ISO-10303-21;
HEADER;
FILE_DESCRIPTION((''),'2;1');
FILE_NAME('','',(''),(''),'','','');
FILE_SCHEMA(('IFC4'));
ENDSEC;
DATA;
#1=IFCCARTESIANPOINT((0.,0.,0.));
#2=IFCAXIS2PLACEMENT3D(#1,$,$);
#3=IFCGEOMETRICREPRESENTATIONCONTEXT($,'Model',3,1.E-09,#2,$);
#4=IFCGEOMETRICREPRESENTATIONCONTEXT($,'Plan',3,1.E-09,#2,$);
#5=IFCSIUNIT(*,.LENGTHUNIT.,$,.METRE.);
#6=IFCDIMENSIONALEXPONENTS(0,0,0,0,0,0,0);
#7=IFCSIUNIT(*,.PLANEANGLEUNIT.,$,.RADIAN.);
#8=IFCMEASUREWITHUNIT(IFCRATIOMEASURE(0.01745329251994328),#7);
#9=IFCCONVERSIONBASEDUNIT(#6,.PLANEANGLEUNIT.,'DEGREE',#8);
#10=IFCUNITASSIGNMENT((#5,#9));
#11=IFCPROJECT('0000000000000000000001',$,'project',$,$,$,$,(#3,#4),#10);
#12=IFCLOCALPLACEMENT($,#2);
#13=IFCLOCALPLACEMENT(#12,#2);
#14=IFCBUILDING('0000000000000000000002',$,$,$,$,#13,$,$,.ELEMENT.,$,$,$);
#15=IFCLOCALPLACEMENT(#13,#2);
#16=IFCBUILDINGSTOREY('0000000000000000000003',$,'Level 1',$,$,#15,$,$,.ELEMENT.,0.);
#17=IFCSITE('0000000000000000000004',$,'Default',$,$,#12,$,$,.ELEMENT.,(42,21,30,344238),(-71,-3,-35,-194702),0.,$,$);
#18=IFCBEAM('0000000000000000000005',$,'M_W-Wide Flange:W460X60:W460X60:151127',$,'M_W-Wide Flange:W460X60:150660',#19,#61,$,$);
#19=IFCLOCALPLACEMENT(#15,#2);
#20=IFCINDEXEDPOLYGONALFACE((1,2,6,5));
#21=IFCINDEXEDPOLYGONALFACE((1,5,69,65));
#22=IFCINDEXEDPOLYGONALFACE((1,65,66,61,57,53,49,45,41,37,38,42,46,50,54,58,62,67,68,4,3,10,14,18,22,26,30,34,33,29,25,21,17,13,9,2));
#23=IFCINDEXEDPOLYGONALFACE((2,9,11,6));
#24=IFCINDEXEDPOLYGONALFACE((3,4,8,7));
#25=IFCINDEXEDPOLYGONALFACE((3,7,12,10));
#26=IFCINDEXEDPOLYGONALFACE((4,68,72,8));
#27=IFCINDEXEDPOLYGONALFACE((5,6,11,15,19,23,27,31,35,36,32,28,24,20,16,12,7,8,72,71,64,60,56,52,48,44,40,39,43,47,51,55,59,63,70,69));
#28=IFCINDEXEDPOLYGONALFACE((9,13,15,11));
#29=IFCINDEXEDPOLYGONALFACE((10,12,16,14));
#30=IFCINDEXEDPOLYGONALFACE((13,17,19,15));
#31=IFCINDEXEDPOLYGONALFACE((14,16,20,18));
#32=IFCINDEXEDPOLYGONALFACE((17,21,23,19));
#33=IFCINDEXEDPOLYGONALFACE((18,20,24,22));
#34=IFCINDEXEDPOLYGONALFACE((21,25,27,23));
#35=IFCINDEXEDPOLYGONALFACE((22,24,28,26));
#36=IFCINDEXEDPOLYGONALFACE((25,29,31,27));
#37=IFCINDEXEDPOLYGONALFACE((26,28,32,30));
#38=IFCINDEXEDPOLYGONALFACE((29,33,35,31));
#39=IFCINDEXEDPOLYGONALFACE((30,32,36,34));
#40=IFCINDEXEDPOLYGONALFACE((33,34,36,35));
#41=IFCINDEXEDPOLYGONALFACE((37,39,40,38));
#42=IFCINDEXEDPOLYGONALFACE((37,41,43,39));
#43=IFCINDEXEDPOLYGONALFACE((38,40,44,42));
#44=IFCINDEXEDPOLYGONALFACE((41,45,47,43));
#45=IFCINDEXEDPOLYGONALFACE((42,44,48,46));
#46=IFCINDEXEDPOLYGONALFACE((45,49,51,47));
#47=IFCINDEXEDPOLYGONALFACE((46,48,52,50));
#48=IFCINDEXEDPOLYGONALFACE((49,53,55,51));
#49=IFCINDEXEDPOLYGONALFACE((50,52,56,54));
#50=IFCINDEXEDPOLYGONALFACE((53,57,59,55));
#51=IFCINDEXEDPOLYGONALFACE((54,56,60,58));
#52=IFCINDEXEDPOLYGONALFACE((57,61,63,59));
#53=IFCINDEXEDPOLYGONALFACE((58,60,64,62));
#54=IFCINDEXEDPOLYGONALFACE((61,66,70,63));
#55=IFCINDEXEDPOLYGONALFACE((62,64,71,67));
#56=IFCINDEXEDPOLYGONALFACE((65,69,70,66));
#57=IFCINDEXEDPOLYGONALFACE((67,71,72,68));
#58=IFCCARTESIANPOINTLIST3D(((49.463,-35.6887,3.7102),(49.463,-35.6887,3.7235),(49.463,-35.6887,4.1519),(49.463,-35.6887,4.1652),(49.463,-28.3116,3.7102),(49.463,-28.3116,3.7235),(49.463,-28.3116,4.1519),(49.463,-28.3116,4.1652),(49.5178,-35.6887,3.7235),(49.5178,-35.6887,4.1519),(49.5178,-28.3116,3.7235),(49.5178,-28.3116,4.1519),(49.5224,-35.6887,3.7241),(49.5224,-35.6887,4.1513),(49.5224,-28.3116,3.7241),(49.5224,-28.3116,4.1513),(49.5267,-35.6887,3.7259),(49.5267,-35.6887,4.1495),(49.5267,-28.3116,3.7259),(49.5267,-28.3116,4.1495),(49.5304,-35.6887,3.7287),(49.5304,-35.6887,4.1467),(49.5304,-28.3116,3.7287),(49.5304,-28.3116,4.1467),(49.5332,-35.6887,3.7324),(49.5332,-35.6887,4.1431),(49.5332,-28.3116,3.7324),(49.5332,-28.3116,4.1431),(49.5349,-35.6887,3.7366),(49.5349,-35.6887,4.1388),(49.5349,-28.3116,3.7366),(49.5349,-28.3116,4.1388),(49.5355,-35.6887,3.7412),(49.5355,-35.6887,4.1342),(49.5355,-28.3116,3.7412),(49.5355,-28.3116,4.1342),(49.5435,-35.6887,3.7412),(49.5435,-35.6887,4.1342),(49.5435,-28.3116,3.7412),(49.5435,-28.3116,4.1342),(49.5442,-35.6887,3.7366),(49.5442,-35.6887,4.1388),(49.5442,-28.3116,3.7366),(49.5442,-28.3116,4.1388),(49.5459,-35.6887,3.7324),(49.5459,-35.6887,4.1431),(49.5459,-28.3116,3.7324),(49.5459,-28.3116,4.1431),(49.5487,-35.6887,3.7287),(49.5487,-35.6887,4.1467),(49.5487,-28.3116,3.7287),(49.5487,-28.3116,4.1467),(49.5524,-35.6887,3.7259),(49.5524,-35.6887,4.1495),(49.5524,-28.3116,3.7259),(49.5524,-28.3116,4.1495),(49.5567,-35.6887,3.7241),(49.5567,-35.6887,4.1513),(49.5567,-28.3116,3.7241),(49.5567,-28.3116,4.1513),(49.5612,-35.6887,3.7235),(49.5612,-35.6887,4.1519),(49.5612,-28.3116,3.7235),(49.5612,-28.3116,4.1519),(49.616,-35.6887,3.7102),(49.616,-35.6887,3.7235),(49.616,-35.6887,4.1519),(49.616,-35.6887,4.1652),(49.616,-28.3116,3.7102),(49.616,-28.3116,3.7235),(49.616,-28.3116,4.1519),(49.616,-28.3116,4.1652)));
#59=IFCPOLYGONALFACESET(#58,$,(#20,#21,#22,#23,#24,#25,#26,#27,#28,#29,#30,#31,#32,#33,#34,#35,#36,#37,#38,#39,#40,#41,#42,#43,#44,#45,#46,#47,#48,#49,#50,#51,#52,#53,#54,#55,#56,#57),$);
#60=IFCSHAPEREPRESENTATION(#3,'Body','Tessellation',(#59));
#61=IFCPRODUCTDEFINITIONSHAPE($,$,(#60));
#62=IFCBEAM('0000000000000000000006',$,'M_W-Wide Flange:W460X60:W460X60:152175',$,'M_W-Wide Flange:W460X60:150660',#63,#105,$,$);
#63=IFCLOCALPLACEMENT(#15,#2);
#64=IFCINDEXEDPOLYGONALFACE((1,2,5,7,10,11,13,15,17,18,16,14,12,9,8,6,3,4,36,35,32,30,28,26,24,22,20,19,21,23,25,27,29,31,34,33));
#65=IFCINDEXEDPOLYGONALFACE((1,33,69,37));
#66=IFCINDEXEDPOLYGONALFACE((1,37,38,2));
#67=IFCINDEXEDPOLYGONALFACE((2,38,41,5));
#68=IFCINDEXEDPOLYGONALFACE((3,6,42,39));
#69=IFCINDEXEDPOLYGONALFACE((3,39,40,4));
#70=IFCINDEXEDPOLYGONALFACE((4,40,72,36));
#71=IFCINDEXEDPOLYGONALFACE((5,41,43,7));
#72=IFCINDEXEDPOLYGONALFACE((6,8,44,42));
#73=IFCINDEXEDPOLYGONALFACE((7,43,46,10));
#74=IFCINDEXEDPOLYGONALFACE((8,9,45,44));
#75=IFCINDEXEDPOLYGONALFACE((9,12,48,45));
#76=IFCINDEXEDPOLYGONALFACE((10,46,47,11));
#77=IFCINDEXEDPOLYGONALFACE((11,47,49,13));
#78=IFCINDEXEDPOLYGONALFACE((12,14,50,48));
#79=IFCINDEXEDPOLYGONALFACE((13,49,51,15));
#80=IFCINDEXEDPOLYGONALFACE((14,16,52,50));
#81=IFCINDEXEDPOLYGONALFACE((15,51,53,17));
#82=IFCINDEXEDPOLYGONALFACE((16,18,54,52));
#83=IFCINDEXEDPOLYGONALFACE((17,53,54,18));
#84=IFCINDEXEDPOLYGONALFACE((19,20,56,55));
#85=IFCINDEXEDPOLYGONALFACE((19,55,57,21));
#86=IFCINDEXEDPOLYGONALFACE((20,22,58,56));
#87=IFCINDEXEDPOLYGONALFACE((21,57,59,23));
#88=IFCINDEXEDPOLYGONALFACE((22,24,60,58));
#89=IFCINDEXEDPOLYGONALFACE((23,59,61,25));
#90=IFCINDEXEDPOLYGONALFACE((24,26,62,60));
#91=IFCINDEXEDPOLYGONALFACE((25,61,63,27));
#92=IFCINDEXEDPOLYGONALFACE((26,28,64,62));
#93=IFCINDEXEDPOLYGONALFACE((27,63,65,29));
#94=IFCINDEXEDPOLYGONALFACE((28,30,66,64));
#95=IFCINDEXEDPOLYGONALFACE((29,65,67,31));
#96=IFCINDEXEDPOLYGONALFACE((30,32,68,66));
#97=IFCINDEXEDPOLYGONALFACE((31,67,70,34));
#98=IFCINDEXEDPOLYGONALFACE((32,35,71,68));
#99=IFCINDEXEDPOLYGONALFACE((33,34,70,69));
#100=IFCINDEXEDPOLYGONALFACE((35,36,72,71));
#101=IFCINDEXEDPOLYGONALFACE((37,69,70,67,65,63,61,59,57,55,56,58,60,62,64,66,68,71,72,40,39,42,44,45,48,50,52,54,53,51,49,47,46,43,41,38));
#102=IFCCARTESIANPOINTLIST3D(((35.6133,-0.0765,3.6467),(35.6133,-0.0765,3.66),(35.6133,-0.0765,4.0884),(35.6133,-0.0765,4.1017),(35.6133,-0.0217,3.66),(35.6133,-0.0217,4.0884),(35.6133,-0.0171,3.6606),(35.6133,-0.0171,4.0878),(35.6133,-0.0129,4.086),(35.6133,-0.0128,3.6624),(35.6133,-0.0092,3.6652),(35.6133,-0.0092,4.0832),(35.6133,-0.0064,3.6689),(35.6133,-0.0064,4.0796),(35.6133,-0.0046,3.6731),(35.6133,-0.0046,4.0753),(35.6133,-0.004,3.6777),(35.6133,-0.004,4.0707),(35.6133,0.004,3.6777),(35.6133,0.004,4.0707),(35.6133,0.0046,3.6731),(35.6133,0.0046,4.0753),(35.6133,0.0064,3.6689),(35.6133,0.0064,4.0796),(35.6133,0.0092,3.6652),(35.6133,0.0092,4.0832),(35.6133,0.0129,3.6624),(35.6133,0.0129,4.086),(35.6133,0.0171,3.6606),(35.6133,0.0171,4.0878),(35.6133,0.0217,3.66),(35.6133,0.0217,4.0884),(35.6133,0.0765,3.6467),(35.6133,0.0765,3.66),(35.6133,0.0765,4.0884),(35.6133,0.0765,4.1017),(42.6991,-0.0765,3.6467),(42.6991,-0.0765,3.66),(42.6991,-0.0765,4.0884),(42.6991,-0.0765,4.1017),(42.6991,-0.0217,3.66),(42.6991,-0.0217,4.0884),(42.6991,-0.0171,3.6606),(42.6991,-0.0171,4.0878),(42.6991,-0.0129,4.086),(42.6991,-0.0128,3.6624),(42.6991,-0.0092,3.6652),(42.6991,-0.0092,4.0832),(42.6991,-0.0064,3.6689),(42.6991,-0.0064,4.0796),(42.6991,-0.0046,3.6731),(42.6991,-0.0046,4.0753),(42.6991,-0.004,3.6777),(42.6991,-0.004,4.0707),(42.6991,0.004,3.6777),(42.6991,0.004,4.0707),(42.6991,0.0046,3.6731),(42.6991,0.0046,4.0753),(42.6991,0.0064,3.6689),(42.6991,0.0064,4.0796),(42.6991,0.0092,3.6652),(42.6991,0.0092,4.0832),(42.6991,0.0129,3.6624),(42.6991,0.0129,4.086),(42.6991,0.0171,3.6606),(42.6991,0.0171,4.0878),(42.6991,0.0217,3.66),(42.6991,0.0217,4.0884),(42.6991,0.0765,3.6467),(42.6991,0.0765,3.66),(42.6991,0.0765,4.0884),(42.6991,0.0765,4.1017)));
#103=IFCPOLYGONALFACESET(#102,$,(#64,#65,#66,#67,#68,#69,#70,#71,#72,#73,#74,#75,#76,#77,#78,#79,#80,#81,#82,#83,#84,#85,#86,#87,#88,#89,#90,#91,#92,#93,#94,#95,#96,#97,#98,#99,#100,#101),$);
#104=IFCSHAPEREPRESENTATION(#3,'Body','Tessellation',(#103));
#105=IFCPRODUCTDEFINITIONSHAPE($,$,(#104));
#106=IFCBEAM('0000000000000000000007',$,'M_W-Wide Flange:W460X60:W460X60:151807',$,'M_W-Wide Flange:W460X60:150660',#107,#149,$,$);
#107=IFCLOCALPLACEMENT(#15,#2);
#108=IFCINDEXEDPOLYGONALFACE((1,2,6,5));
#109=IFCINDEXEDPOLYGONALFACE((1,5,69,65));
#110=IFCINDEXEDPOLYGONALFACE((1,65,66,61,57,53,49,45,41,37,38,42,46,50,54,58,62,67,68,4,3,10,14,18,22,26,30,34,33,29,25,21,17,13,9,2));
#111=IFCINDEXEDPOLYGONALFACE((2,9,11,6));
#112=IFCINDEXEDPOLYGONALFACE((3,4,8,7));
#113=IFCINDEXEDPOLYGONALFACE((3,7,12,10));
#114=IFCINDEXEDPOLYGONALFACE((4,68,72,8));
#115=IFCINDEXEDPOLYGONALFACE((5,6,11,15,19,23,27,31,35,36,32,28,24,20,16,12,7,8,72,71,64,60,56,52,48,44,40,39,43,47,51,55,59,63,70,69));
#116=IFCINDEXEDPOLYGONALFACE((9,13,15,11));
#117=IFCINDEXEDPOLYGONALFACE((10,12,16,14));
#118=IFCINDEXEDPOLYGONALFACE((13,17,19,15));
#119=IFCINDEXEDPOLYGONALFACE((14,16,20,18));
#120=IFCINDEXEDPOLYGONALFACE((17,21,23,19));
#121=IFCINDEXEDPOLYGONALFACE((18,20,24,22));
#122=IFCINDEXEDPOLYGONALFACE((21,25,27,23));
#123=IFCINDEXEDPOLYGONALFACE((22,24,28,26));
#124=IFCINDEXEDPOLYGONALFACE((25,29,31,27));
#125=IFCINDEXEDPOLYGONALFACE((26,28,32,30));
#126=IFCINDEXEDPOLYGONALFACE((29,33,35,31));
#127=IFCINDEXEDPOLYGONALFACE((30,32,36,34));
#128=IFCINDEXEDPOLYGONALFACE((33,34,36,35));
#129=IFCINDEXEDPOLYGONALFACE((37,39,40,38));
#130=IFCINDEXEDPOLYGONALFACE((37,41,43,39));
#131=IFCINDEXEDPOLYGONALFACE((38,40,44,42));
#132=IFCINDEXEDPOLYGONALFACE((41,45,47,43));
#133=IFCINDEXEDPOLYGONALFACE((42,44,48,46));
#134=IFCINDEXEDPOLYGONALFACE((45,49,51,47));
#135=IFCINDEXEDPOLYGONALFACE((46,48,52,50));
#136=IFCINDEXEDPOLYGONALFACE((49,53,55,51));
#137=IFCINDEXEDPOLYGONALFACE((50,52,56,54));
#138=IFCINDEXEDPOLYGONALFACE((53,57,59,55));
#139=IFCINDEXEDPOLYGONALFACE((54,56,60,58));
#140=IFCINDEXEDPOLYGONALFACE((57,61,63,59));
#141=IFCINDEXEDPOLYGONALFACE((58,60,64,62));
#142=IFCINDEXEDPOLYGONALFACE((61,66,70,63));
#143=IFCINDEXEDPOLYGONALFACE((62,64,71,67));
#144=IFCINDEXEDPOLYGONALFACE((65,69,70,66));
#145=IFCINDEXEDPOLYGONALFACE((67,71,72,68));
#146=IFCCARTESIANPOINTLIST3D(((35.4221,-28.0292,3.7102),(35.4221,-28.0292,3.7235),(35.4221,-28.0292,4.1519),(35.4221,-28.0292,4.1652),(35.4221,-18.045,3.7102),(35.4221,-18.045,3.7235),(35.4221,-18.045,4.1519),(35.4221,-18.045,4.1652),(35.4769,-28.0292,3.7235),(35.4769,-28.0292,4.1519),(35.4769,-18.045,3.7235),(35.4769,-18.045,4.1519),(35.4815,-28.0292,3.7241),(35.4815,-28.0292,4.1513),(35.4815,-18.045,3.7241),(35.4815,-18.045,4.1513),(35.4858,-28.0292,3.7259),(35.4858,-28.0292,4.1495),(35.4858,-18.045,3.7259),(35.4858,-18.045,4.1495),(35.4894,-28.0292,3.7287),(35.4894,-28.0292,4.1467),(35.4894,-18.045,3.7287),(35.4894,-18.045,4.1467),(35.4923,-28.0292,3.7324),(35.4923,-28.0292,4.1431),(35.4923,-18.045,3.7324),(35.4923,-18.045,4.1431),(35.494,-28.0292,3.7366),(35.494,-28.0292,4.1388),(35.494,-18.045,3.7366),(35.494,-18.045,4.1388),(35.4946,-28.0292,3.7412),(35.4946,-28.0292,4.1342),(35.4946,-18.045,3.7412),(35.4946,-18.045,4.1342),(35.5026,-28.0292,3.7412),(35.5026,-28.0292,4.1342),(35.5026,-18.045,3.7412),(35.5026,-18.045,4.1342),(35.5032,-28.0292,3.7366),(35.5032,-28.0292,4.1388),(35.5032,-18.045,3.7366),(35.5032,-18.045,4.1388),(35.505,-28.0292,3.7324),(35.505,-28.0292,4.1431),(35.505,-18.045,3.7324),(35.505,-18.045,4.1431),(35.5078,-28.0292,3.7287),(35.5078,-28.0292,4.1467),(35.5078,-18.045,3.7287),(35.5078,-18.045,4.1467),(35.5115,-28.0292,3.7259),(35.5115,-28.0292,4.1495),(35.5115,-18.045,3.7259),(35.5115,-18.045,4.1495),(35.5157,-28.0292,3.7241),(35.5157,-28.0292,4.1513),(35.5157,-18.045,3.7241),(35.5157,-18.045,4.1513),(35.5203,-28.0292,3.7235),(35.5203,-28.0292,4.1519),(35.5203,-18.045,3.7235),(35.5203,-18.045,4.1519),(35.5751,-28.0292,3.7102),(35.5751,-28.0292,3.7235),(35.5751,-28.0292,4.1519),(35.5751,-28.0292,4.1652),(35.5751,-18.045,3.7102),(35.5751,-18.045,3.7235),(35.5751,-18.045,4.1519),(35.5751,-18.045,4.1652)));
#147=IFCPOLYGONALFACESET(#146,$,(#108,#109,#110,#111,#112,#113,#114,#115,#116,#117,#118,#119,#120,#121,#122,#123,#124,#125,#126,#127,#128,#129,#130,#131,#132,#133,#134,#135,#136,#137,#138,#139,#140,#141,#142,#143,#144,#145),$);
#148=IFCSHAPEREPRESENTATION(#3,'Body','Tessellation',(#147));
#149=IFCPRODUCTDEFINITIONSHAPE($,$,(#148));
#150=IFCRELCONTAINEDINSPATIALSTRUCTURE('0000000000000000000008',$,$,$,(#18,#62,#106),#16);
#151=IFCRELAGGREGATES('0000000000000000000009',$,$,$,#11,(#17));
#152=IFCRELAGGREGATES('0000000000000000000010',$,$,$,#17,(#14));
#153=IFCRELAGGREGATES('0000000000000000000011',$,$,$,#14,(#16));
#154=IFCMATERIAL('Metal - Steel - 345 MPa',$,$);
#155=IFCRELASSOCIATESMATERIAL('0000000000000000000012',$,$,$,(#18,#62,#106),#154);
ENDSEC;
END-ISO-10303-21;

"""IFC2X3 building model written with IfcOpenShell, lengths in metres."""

from ifc_helpers import new_model, entity, si_unit, converted_unit, frame, frame_2d, origin, place, context, project, spatial, polyline, circle_curve, parameter, trimmed, segment, composite_curve, outline, extrude, material, element, save


model = new_model("IFC2X3")

# Units and contexts
model_context = context("Model", 3, precision=1e-09, world=origin())
plan_context = context("Plan", 3, precision=1e-09, world=origin())
ifc_project = project(units=[si_unit("LENGTHUNIT", "METRE"), converted_unit("PLANEANGLEUNIT", "DEGREE", entity("IfcRatioMeasure", 0.01745329251994328), si_unit("PLANEANGLEUNIT", "RADIAN"), dimensions=[0, 0, 0, 0, 0, 0, 0])], contexts=[model_context, plan_context])

# Site, building, storey
site_placement = place(None, origin())
site = spatial("IfcSite", under=ifc_project, at=site_placement, Name="Default", CompositionType="ELEMENT", RefLatitude=(42, 21, 30, 344238), RefLongitude=(-71, -3, -35, -194702), RefElevation=0.0)
building_placement = place(site_placement, origin())
building = spatial("IfcBuilding", under=site, at=building_placement, CompositionType="ELEMENT")
storey_placement = place(building_placement, origin())
storey = spatial("IfcBuildingStorey", under=building, at=storey_placement, Name="Level 1", CompositionType="ELEMENT", Elevation=0.0)

# Beams
ifc_material = material(Name="Metal - Steel - 345 MPa")
beam_1_placement = place(storey_placement, frame((49.5395, -28.1704, 4.2672), z_axis=(0.0, 0.0, 1.0), x_axis=(-1.0, 0.0, 0.0)))
element("IfcBeam", 1, at=beam_1_placement, inside=storey, material=ifc_material, Name="M_W-Wide Flange:W460X60:W460X60:151127", ObjectType="M_W-Wide Flange:W460X60:150660", context=model_context, shape_type="SweptSolid", body=[
    extrude(outline(composite_curve([segment(polyline([(0.2142, -0.0765), (0.2275, -0.0765)]), True, "CONTINUOUS"), segment(polyline([(0.2275, -0.0765), (0.2275, 0.0765)]), True, "CONTINUOUS"), segment(polyline([(0.2275, 0.0765), (0.2142, 0.0765)]), True, "CONTINUOUS"), segment(polyline([(0.2142, 0.0765), (0.2142, 0.0217)]), True, "CONTINUOUS"), segment(trimmed(circle_curve(frame_2d((0.1965, 0.0217), x_axis=(1.0, 0.0)), 0.0177), [parameter(270.0)], [parameter(360.0)], True, "PARAMETER"), False, "CONTINUOUS"), segment(polyline([(0.1965, 0.004), (-0.1965, 0.004)]), True, "CONTINUOUS"), segment(trimmed(circle_curve(frame_2d((-0.1965, 0.0217), x_axis=(0.0, -1.0)), 0.0177), [parameter(270.0)], [parameter(360.0)], True, "PARAMETER"), False, "CONTINUOUS"), segment(polyline([(-0.2142, 0.0217), (-0.2142, 0.0765)]), True, "CONTINUOUS"), segment(polyline([(-0.2142, 0.0765), (-0.2275, 0.0765)]), True, "CONTINUOUS"), segment(polyline([(-0.2275, 0.0765), (-0.2275, -0.0765)]), True, "CONTINUOUS"), segment(polyline([(-0.2275, -0.0765), (-0.2142, -0.0765)]), True, "CONTINUOUS"), segment(polyline([(-0.2142, -0.0765), (-0.2142, -0.0217)]), True, "CONTINUOUS"), segment(trimmed(circle_curve(frame_2d((-0.1965, -0.0217), x_axis=(-1.0, 0.0)), 0.0177), [parameter(270.0)], [parameter(360.0)], True, "PARAMETER"), False, "CONTINUOUS"), segment(polyline([(-0.1965, -0.004), (0.1965, -0.004)]), True, "CONTINUOUS"), segment(trimmed(circle_curve(frame_2d((0.1965, -0.0217), x_axis=(0.0, 1.0)), 0.0177), [parameter(270.0)], [parameter(0.0)], True, "PARAMETER"), False, "CONTINUOUS"), segment(polyline([(0.2142, -0.0217), (0.2142, -0.0765)]), True, "CONTINUOUS")], self_intersect=False)), frame((0.0, 7.5183, -0.3295), z_axis=(0.0, -1.0, 0.0), x_axis=(0.0, 0.0, -1.0)), (0.0, 0.0, 1.0), 7.3771),
])
beam_2_placement = place(storey_placement, frame((35.4986, 0.0, 4.2672), z_axis=(0.0, 0.0, 1.0), x_axis=(0.0, -1.0, 0.0)))
element("IfcBeam", 2, at=beam_2_placement, inside=storey, material=ifc_material, Name="M_W-Wide Flange:W460X60:W460X60:152175", ObjectType="M_W-Wide Flange:W460X60:150660", context=model_context, shape_type="SweptSolid", body=[
    extrude(outline(composite_curve([segment(polyline([(-0.0765, -0.2142), (-0.0765, -0.2275)]), True, "CONTINUOUS"), segment(polyline([(-0.0765, -0.2275), (0.0765, -0.2275)]), True, "CONTINUOUS"), segment(polyline([(0.0765, -0.2275), (0.0765, -0.2142)]), True, "CONTINUOUS"), segment(polyline([(0.0765, -0.2142), (0.0217, -0.2142)]), True, "CONTINUOUS"), segment(trimmed(circle_curve(frame_2d((0.0217, -0.1965), x_axis=(0.0, -1.0)), 0.0177), [parameter(270.0)], [parameter(360.0)], True, "PARAMETER"), False, "CONTINUOUS"), segment(polyline([(0.004, -0.1965), (0.004, 0.1965)]), True, "CONTINUOUS"), segment(trimmed(circle_curve(frame_2d((0.0217, 0.1965), x_axis=(-1.0, 0.0)), 0.0177), [parameter(270.0)], [parameter(360.0)], True, "PARAMETER"), False, "CONTINUOUS"), segment(polyline([(0.0217, 0.2142), (0.0765, 0.2142)]), True, "CONTINUOUS"), segment(polyline([(0.0765, 0.2142), (0.0765, 0.2275)]), True, "CONTINUOUS"), segment(polyline([(0.0765, 0.2275), (-0.0765, 0.2275)]), True, "CONTINUOUS"), segment(polyline([(-0.0765, 0.2275), (-0.0765, 0.2142)]), True, "CONTINUOUS"), segment(polyline([(-0.0765, 0.2142), (-0.0217, 0.2142)]), True, "CONTINUOUS"), segment(trimmed(circle_curve(frame_2d((-0.0217, 0.1965), x_axis=(0.0, 1.0)), 0.0177), [parameter(270.0)], [parameter(360.0)], True, "PARAMETER"), False, "CONTINUOUS"), segment(polyline([(-0.004, 0.1965), (-0.004, -0.1965)]), True, "CONTINUOUS"), segment(trimmed(circle_curve(frame_2d((-0.0217, -0.1965), x_axis=(1.0, 0.0)), 0.0177), [parameter(270.0)], [parameter(0.0)], True, "PARAMETER"), False, "CONTINUOUS"), segment(polyline([(-0.0217, -0.2142), (-0.0765, -0.2142)]), True, "CONTINUOUS")], self_intersect=False)), frame((0.0, 0.1147, -0.393), z_axis=(0.0, -1.0, 0.0), x_axis=(1.0, 0.0, 0.0)), (0.0, 0.0, -1.0), 7.0858),
])
beam_3_placement = place(storey_placement, frame((35.4986, -28.1704, 4.2672)))
element("IfcBeam", 3, at=beam_3_placement, inside=storey, material=ifc_material, Name="M_W-Wide Flange:W460X60:W460X60:151807", ObjectType="M_W-Wide Flange:W460X60:150660", context=model_context, shape_type="SweptSolid", body=[
    extrude(outline(composite_curve([segment(polyline([(-0.0765, -0.2142), (-0.0765, -0.2275)]), True, "CONTINUOUS"), segment(polyline([(-0.0765, -0.2275), (0.0765, -0.2275)]), True, "CONTINUOUS"), segment(polyline([(0.0765, -0.2275), (0.0765, -0.2142)]), True, "CONTINUOUS"), segment(polyline([(0.0765, -0.2142), (0.0217, -0.2142)]), True, "CONTINUOUS"), segment(trimmed(circle_curve(frame_2d((0.0217, -0.1965), x_axis=(0.0, -1.0)), 0.0177), [parameter(270.0)], [parameter(360.0)], True, "PARAMETER"), False, "CONTINUOUS"), segment(polyline([(0.004, -0.1965), (0.004, 0.1965)]), True, "CONTINUOUS"), segment(trimmed(circle_curve(frame_2d((0.0217, 0.1965), x_axis=(-1.0, 0.0)), 0.0177), [parameter(270.0)], [parameter(360.0)], True, "PARAMETER"), False, "CONTINUOUS"), segment(polyline([(0.0217, 0.2142), (0.0765, 0.2142)]), True, "CONTINUOUS"), segment(polyline([(0.0765, 0.2142), (0.0765, 0.2275)]), True, "CONTINUOUS"), segment(polyline([(0.0765, 0.2275), (-0.0765, 0.2275)]), True, "CONTINUOUS"), segment(polyline([(-0.0765, 0.2275), (-0.0765, 0.2142)]), True, "CONTINUOUS"), segment(polyline([(-0.0765, 0.2142), (-0.0217, 0.2142)]), True, "CONTINUOUS"), segment(trimmed(circle_curve(frame_2d((-0.0217, 0.1965), x_axis=(0.0, 1.0)), 0.0177), [parameter(270.0)], [parameter(360.0)], True, "PARAMETER"), False, "CONTINUOUS"), segment(polyline([(-0.004, 0.1965), (-0.004, -0.1965)]), True, "CONTINUOUS"), segment(trimmed(circle_curve(frame_2d((-0.0217, -0.1965), x_axis=(1.0, 0.0)), 0.0177), [parameter(270.0)], [parameter(0.0)], True, "PARAMETER"), False, "CONTINUOUS"), segment(polyline([(-0.0217, -0.2142), (-0.0765, -0.2142)]), True, "CONTINUOUS")], self_intersect=False)), frame((0.0, 0.1412, -0.3295), z_axis=(0.0, -1.0, 0.0), x_axis=(1.0, 0.0, 0.0)), (0.0, 0.0, -1.0), 9.9841),
])

save(model, "model.ifc")
